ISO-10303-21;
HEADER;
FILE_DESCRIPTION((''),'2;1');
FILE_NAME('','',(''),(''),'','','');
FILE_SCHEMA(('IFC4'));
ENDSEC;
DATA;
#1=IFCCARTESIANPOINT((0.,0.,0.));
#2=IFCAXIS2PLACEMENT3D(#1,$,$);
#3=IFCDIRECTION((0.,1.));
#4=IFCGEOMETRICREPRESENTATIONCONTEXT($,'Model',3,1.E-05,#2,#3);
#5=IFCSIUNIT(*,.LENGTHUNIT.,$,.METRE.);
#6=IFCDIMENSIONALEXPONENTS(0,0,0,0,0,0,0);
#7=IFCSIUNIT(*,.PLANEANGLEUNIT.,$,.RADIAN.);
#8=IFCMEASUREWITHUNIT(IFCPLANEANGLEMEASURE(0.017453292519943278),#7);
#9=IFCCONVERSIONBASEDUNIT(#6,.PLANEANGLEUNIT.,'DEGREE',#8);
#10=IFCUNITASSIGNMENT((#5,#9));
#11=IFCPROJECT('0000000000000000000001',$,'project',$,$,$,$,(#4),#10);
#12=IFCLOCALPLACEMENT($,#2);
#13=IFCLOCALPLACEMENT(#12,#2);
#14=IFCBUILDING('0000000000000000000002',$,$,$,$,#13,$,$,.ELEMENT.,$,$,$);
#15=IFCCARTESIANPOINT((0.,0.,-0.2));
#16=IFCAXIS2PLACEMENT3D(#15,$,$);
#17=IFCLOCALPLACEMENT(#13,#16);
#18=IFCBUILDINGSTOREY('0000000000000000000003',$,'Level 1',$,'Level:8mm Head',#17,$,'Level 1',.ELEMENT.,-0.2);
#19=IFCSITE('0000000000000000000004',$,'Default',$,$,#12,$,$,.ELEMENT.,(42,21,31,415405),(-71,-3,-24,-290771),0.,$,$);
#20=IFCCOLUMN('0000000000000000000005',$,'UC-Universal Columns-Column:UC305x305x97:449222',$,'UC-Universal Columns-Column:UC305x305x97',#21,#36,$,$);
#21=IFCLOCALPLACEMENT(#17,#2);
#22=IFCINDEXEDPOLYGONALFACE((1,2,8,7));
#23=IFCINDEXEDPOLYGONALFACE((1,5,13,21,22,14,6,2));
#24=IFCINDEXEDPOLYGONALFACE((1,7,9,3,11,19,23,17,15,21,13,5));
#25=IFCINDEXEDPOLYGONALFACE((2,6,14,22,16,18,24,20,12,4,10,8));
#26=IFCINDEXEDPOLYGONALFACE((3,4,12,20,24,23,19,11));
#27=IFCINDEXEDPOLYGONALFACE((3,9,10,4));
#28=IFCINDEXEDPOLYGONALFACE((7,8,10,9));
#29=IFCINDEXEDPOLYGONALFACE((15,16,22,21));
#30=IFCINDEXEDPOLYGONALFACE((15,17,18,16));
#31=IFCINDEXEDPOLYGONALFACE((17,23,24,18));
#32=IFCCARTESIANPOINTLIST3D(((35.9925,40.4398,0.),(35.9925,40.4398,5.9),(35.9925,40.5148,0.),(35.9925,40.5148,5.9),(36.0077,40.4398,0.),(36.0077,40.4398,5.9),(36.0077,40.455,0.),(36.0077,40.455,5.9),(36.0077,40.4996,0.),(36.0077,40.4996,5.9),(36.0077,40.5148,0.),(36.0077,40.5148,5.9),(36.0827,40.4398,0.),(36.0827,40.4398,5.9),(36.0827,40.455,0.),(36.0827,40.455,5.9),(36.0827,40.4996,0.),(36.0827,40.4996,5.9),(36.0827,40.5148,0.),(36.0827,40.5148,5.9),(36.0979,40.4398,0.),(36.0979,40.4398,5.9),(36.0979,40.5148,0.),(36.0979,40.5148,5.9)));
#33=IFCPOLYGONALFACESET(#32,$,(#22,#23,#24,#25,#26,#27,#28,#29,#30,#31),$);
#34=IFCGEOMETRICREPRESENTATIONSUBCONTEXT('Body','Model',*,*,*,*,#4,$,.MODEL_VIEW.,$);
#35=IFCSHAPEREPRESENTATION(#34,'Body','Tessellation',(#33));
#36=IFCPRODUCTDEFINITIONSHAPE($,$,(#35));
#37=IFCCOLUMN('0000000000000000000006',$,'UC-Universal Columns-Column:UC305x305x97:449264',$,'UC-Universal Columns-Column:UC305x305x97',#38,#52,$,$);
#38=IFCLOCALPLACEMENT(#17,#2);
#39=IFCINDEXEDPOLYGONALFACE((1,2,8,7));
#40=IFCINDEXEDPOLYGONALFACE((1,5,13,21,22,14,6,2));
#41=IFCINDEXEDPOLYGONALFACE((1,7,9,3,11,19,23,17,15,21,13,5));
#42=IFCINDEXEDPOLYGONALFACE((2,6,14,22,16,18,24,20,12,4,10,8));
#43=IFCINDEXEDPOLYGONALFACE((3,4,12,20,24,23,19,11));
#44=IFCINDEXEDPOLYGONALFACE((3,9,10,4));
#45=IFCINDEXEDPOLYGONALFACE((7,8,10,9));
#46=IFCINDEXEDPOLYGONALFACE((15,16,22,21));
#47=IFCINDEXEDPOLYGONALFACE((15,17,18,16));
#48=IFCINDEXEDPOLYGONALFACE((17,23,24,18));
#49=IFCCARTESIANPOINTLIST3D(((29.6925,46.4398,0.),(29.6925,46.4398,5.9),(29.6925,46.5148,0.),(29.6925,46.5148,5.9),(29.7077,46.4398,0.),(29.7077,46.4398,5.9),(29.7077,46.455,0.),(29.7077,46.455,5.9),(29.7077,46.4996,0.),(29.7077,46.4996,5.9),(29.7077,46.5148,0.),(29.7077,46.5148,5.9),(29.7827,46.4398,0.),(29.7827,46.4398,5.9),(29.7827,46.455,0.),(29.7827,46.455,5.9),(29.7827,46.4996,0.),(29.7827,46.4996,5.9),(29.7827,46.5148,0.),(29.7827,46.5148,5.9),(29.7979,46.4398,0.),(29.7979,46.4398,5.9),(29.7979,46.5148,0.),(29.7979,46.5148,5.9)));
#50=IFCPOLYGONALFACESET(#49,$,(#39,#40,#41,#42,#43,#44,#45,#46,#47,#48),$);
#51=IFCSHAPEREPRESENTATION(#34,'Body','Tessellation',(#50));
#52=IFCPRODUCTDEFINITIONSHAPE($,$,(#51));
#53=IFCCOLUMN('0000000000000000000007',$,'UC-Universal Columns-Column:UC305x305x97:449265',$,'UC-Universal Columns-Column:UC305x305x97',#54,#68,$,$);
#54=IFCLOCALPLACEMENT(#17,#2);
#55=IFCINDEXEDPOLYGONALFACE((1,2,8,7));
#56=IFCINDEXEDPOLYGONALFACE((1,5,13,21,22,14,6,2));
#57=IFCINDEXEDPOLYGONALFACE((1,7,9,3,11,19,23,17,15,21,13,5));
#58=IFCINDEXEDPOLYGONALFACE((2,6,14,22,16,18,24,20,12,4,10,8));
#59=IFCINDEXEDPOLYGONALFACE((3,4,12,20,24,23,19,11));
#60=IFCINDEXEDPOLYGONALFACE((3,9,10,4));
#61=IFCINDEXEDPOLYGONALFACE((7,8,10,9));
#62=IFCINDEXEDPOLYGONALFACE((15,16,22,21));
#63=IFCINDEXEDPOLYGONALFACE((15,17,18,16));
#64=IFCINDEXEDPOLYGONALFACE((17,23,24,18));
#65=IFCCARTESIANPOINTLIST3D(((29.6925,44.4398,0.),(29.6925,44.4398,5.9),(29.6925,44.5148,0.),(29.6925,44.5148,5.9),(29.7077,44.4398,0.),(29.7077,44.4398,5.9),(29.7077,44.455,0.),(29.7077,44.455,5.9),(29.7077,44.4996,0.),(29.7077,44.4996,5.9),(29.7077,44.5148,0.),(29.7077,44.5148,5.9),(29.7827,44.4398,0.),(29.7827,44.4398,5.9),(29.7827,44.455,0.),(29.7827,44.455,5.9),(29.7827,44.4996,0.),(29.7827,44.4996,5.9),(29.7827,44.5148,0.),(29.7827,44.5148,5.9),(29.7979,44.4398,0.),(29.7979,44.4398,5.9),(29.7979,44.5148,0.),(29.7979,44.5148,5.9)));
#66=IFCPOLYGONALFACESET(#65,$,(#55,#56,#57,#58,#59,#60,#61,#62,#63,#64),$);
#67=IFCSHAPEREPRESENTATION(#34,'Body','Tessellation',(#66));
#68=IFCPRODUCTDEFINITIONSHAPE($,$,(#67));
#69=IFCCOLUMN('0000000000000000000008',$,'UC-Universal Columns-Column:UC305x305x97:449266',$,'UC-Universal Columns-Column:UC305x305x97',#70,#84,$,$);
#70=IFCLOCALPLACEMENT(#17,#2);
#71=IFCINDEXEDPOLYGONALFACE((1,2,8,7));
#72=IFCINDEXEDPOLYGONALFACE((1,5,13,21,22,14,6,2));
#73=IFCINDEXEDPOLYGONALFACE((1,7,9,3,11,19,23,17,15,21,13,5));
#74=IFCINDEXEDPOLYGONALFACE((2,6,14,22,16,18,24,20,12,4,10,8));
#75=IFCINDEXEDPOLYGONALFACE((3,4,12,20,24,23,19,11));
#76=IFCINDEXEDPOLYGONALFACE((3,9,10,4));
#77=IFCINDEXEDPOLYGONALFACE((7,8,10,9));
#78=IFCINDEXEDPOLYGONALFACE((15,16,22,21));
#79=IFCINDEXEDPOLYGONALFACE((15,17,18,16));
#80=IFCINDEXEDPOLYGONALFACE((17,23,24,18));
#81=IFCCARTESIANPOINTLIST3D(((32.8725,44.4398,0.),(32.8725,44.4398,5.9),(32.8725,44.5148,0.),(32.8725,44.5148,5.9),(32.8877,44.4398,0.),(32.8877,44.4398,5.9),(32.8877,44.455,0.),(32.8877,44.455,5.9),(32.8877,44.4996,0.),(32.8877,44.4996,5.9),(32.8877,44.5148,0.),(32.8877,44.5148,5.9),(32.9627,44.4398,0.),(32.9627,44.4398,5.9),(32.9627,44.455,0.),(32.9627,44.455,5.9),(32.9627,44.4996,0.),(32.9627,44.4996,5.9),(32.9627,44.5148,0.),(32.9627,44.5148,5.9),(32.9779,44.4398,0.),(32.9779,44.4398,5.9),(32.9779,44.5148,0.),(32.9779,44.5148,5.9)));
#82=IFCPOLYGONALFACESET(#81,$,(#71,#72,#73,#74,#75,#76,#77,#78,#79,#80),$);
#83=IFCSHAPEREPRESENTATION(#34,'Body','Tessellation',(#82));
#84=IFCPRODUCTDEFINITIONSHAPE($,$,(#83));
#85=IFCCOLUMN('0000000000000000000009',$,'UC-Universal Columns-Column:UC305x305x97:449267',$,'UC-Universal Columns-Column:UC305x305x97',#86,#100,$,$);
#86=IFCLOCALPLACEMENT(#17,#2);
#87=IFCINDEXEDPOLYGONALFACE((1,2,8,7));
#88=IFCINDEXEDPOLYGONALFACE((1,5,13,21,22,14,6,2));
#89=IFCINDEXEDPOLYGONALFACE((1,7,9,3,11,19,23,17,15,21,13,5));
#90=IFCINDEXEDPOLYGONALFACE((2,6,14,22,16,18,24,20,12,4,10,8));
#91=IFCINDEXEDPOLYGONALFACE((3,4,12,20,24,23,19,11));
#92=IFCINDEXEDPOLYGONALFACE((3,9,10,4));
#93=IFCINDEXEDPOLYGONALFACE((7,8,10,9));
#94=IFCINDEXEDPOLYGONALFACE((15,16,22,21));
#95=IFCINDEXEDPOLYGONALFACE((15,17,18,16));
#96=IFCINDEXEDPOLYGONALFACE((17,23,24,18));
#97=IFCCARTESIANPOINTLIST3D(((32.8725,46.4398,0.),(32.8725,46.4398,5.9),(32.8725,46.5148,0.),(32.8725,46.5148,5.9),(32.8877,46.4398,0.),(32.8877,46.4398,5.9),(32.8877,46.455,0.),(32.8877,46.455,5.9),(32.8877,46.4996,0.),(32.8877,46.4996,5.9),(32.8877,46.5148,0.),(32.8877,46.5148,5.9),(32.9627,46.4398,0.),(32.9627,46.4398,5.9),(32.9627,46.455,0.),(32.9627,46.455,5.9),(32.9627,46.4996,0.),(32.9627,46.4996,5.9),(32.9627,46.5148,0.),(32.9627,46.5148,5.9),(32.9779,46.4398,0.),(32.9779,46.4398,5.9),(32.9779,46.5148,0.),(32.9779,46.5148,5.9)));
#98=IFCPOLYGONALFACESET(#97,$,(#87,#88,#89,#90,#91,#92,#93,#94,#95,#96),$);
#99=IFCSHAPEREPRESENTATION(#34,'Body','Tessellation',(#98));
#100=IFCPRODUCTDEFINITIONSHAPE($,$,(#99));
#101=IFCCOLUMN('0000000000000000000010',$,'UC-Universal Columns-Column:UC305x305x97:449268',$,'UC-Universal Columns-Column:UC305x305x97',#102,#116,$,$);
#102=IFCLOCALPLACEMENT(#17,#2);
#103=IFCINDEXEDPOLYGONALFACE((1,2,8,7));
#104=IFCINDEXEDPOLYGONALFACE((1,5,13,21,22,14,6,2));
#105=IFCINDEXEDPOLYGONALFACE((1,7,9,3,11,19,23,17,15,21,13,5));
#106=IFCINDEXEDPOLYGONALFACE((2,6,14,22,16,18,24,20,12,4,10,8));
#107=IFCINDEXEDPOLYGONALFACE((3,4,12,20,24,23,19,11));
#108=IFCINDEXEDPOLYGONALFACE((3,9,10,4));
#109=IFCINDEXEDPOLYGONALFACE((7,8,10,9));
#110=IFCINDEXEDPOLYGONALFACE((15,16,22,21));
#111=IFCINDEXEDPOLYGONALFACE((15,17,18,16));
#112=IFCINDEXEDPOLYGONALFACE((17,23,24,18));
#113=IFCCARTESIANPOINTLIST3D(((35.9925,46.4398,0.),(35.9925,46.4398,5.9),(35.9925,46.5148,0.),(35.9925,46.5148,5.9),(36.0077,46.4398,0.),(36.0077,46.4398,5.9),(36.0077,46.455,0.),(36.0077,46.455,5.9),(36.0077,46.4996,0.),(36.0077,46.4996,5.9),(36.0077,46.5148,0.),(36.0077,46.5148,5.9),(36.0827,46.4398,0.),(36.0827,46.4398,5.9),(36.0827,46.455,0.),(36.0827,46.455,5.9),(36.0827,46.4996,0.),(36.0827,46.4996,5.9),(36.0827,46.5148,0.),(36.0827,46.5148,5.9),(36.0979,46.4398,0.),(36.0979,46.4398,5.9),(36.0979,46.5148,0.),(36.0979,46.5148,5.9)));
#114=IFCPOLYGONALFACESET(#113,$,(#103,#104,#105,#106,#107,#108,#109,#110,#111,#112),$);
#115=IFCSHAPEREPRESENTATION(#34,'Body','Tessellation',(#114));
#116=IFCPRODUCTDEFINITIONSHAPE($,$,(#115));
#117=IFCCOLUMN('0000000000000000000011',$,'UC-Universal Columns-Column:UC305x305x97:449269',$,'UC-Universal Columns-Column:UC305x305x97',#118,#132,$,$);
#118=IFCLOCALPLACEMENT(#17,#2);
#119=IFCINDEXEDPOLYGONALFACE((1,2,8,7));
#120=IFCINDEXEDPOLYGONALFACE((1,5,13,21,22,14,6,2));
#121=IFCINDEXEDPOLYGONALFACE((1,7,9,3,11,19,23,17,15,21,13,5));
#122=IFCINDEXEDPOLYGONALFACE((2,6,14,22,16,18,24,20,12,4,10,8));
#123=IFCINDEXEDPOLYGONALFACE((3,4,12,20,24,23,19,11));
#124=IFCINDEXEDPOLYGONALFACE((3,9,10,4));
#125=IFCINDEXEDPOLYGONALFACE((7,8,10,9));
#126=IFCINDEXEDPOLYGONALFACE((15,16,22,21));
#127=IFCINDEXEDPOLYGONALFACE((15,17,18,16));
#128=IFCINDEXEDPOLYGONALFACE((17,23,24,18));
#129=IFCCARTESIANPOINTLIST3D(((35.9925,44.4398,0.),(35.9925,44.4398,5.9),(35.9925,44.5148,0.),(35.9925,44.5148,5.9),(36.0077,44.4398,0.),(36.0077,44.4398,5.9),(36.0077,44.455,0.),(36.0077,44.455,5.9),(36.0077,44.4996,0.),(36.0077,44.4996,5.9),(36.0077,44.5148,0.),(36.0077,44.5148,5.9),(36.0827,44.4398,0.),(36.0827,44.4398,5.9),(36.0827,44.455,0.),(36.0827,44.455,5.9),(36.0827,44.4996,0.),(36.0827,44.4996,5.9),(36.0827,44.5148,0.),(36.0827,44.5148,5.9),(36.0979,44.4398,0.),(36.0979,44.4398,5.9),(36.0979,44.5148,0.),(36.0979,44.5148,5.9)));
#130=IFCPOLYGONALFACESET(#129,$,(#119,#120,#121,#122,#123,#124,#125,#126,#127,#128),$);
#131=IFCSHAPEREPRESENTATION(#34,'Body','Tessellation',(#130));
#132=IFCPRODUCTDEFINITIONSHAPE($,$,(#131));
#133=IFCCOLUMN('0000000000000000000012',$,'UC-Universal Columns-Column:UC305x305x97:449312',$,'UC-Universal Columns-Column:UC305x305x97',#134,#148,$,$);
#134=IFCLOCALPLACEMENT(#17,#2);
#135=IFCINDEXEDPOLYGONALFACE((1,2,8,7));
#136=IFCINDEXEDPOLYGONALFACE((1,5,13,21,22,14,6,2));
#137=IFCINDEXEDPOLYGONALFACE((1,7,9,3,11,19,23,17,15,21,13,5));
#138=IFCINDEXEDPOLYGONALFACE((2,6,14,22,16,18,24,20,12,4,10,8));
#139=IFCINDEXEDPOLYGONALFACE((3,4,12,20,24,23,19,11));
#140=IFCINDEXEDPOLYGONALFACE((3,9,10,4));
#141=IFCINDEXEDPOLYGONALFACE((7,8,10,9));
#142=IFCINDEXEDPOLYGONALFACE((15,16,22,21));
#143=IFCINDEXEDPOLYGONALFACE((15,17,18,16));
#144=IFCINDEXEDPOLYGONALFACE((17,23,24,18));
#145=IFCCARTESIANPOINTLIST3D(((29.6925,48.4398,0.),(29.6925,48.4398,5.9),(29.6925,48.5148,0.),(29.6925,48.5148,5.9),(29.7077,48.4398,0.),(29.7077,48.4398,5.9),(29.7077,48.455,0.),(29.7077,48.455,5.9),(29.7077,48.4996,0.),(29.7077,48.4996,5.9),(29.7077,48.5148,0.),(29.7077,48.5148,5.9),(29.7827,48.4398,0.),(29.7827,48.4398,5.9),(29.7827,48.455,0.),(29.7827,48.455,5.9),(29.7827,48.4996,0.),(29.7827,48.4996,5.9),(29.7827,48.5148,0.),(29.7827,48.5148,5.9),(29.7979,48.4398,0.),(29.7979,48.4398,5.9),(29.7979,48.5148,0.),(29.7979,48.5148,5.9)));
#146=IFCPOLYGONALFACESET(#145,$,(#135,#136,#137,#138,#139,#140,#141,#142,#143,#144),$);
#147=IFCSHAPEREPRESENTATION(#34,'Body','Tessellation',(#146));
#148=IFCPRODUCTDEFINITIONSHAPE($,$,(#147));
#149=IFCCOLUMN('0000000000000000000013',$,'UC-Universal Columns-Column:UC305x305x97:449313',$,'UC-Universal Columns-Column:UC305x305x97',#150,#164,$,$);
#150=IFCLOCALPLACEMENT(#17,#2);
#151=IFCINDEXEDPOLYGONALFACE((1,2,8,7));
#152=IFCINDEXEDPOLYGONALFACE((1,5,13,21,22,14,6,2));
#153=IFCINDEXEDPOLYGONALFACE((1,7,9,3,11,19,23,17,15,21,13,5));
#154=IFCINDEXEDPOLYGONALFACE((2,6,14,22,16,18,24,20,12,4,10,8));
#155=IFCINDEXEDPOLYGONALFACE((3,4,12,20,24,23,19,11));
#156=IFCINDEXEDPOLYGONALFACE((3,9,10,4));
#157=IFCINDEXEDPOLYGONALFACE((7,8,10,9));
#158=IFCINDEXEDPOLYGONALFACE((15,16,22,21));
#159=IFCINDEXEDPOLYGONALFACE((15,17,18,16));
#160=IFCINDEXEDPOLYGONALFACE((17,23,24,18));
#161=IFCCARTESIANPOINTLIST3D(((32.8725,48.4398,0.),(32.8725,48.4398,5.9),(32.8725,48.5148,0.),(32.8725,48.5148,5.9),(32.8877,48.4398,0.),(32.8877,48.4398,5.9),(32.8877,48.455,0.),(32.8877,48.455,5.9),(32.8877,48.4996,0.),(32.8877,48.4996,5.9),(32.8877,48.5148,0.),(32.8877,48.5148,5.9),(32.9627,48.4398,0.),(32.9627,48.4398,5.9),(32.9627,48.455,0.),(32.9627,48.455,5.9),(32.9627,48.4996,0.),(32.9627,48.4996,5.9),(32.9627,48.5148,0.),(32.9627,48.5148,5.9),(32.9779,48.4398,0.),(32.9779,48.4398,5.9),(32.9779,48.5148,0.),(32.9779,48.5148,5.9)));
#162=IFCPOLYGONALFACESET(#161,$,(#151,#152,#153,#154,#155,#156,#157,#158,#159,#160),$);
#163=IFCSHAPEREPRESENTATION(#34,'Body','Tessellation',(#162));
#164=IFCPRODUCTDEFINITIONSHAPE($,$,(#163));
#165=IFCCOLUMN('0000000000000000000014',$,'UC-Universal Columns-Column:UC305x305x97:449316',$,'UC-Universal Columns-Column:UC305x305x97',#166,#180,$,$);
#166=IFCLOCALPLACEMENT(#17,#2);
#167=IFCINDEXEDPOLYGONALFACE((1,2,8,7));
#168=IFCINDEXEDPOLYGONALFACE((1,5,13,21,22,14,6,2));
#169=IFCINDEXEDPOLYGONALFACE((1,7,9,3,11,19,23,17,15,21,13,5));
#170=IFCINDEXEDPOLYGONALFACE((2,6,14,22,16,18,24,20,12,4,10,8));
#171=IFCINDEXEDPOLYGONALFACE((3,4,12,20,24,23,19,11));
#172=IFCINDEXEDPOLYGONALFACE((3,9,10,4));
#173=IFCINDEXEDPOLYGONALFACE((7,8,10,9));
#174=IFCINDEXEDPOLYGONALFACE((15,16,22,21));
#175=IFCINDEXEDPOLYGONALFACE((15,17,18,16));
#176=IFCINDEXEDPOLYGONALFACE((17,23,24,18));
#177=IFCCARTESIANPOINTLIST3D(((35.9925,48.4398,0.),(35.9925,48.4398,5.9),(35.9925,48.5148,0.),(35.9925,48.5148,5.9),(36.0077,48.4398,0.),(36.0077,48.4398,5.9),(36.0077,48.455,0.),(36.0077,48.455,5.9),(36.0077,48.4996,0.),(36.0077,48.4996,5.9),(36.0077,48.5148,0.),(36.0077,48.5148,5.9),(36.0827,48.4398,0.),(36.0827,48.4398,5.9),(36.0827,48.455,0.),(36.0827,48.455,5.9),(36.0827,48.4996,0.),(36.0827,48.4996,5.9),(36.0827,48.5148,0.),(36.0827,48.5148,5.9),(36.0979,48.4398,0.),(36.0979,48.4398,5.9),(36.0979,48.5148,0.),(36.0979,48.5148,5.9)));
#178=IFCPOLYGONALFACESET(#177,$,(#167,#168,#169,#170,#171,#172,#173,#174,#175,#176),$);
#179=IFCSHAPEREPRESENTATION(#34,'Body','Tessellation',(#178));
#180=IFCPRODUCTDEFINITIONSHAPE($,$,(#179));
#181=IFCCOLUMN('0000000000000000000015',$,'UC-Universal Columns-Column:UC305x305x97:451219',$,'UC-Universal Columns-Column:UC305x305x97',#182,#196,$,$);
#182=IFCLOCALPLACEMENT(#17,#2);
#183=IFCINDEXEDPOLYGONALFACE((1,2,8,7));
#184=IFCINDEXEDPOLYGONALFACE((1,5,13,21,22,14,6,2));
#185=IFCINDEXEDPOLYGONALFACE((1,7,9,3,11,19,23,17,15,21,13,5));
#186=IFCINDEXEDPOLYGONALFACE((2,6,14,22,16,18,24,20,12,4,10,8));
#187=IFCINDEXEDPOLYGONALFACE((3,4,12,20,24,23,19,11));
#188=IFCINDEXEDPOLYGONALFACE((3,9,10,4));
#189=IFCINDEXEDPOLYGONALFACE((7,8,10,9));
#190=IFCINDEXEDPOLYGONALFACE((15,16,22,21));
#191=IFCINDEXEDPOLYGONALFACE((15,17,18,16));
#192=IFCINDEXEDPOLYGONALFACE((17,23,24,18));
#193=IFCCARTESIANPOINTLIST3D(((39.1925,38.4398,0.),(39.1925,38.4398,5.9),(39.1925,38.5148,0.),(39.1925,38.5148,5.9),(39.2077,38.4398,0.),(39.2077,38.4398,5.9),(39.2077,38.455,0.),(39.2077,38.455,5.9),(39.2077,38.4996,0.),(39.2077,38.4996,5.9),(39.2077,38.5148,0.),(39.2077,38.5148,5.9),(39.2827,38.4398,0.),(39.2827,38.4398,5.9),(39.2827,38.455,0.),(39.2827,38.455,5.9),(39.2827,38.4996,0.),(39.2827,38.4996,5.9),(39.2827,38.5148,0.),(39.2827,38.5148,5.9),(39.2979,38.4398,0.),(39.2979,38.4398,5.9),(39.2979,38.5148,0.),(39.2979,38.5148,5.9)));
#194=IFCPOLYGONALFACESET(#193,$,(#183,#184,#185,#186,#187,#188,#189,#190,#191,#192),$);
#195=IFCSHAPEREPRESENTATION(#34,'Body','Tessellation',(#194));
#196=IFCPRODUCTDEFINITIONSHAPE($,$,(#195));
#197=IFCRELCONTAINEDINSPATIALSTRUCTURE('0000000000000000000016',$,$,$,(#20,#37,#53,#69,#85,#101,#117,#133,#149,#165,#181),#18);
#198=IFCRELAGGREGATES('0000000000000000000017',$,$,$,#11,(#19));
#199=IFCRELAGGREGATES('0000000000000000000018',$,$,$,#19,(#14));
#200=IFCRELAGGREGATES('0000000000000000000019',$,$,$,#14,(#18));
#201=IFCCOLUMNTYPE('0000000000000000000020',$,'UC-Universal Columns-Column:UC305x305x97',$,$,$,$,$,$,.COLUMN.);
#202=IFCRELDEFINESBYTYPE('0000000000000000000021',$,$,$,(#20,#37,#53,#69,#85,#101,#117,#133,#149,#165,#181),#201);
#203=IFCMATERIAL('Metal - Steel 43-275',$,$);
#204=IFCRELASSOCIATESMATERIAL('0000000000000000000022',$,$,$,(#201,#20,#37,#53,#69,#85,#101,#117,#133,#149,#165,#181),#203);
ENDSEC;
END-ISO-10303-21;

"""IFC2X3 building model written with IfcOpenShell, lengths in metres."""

from ifc_helpers import new_model, entity, si_unit, converted_unit, direction, frame, frame_2d, origin, place, context, subcontext, project, spatial, polyline, circle_curve, parameter, trimmed, segment, composite_curve, outline, extrude, source, transform, mapped, material, type_object, type_shapes, element, save


model = new_model("IFC2X3")

# Units and contexts
model_context = context("Model", 3, precision=1e-05, world=origin(), true_north=direction((0.0, 1.0)))
body_context = subcontext(model_context, "Body", "Model", "MODEL_VIEW")
ifc_project = project(units=[si_unit("LENGTHUNIT", "METRE"), converted_unit("PLANEANGLEUNIT", "DEGREE", entity("IfcPlaneAngleMeasure", 0.017453292519943278), si_unit("PLANEANGLEUNIT", "RADIAN"), dimensions=[0, 0, 0, 0, 0, 0, 0])], contexts=[model_context])

# Site, building, storey
site_placement = place(None, origin())
site = spatial("IfcSite", under=ifc_project, at=site_placement, Name="Default", CompositionType="ELEMENT", RefLatitude=(42, 21, 31, 415405), RefLongitude=(-71, -3, -24, -290771), RefElevation=0.0)
building_placement = place(site_placement, origin())
building = spatial("IfcBuilding", under=site, at=building_placement, CompositionType="ELEMENT")
storey_placement = place(building_placement, frame((0.0, 0.0, -0.2)))
storey = spatial("IfcBuildingStorey", under=building, at=storey_placement, Name="Level 1", ObjectType="Level:8mm Head", LongName="Level 1", CompositionType="ELEMENT", Elevation=-0.2)

# Columns
ifc_material = material(Name="Metal - Steel 43-275")
column_type = type_object("IfcColumnType", Name="UC-Universal Columns-Column:UC305x305x97", PredefinedType="COLUMN", material=ifc_material)
shared_shape = source(origin(), body_context, "Body", "SweptSolid", [
    extrude(outline(composite_curve([segment(polyline([(-0.0375, -0.0375), (0.0375, -0.0375)]), True, "CONTINUOUS"), segment(polyline([(0.0375, -0.0375), (0.0527, -0.0375)]), True, "CONTINUOUS"), segment(trimmed(circle_curve(frame_2d((0.0527, -0.0223), x_axis=(-1.0, 0.0)), 0.0152), [parameter(0.0)], [parameter(90.0)], True, "PARAMETER"), False, "CONTINUOUS"), segment(polyline([(0.0375, -0.0223), (0.0375, 0.0223)]), True, "CONTINUOUS"), segment(trimmed(circle_curve(frame_2d((0.0527, 0.0223), x_axis=(-1.0, 0.0)), 0.0152), [parameter(270.0)], [parameter(0.0)], True, "PARAMETER"), False, "CONTINUOUS"), segment(polyline([(0.0527, 0.0375), (0.0375, 0.0375)]), True, "CONTINUOUS"), segment(polyline([(0.0375, 0.0375), (-0.0375, 0.0375)]), True, "CONTINUOUS"), segment(polyline([(-0.0375, 0.0375), (-0.0527, 0.0375)]), True, "CONTINUOUS"), segment(trimmed(circle_curve(frame_2d((-0.0527, 0.0223), x_axis=(-1.0, 0.0)), 0.0152), [parameter(180.0)], [parameter(270.0)], True, "PARAMETER"), False, "CONTINUOUS"), segment(polyline([(-0.0375, 0.0223), (-0.0375, -0.0223)]), True, "CONTINUOUS"), segment(trimmed(circle_curve(frame_2d((-0.0527, -0.0223), x_axis=(-1.0, 0.0)), 0.0152), [parameter(90.0)], [parameter(180.0)], True, "PARAMETER"), False, "CONTINUOUS"), segment(polyline([(-0.0527, -0.0375), (-0.0375, -0.0375)]), True, "CONTINUOUS")], self_intersect=False)), frame((0.0, 0.0, -0.2), z_axis=(0.0, 0.0, 1.0), x_axis=(-1.0, 0.0, 0.0)), (0.0, 0.0, 1.0), 5.9),
])
type_shapes(column_type, [shared_shape])
for number, where, z_axis, x_axis, name in (
    (1, (36.0452, 40.4773, 0.2), (0.0, 0.0, 1.0), (-1.0, 0.0, 0.0), "UC-Universal Columns-Column:UC305x305x97:449222"),
    (2, (29.7452, 46.4773, 0.2), (0.0, 0.0, 1.0), (-1.0, 0.0, 0.0), "UC-Universal Columns-Column:UC305x305x97:449264"),
    (3, (29.7452, 44.4773, 0.2), (0.0, 0.0, 1.0), (-1.0, 0.0, 0.0), "UC-Universal Columns-Column:UC305x305x97:449265"),
    (4, (32.9252, 44.4773, 0.2), (0.0, 0.0, 1.0), (-1.0, 0.0, 0.0), "UC-Universal Columns-Column:UC305x305x97:449266"),
    (5, (32.9252, 46.4773, 0.2), (0.0, 0.0, 1.0), (-1.0, 0.0, 0.0), "UC-Universal Columns-Column:UC305x305x97:449267"),
    (6, (36.0452, 46.4773, 0.2), (0.0, 0.0, 1.0), (-1.0, 0.0, 0.0), "UC-Universal Columns-Column:UC305x305x97:449268"),
    (7, (36.0452, 44.4773, 0.2), (0.0, 0.0, 1.0), (-1.0, 0.0, 0.0), "UC-Universal Columns-Column:UC305x305x97:449269"),
    (8, (29.7452, 48.4773, 0.2), (0.0, 0.0, 1.0), (-1.0, 0.0, 0.0), "UC-Universal Columns-Column:UC305x305x97:449312"),
    (9, (32.9252, 48.4773, 0.2), (0.0, 0.0, 1.0), (-1.0, 0.0, 0.0), "UC-Universal Columns-Column:UC305x305x97:449313"),
    (10, (36.0452, 48.4773, 0.2), (0.0, 0.0, 1.0), (-1.0, 0.0, 0.0), "UC-Universal Columns-Column:UC305x305x97:449316"),
    (11, (39.2452, 38.4773, 0.2), (0.0, 0.0, 1.0), (-1.0, 0.0, 0.0), "UC-Universal Columns-Column:UC305x305x97:451219"),
):
    element("IfcColumn", number, at=place(storey_placement, frame(where, z_axis=z_axis, x_axis=x_axis)), inside=storey, type_object=column_type, material=ifc_material, Name=name, ObjectType="UC-Universal Columns-Column:UC305x305x97", context=body_context, shape_type="MappedRepresentation", body=[
        mapped(shared_shape, transform((0.0, 0.0, 0.0), scale=1.0)),
    ])

save(model, "model.ifc")
